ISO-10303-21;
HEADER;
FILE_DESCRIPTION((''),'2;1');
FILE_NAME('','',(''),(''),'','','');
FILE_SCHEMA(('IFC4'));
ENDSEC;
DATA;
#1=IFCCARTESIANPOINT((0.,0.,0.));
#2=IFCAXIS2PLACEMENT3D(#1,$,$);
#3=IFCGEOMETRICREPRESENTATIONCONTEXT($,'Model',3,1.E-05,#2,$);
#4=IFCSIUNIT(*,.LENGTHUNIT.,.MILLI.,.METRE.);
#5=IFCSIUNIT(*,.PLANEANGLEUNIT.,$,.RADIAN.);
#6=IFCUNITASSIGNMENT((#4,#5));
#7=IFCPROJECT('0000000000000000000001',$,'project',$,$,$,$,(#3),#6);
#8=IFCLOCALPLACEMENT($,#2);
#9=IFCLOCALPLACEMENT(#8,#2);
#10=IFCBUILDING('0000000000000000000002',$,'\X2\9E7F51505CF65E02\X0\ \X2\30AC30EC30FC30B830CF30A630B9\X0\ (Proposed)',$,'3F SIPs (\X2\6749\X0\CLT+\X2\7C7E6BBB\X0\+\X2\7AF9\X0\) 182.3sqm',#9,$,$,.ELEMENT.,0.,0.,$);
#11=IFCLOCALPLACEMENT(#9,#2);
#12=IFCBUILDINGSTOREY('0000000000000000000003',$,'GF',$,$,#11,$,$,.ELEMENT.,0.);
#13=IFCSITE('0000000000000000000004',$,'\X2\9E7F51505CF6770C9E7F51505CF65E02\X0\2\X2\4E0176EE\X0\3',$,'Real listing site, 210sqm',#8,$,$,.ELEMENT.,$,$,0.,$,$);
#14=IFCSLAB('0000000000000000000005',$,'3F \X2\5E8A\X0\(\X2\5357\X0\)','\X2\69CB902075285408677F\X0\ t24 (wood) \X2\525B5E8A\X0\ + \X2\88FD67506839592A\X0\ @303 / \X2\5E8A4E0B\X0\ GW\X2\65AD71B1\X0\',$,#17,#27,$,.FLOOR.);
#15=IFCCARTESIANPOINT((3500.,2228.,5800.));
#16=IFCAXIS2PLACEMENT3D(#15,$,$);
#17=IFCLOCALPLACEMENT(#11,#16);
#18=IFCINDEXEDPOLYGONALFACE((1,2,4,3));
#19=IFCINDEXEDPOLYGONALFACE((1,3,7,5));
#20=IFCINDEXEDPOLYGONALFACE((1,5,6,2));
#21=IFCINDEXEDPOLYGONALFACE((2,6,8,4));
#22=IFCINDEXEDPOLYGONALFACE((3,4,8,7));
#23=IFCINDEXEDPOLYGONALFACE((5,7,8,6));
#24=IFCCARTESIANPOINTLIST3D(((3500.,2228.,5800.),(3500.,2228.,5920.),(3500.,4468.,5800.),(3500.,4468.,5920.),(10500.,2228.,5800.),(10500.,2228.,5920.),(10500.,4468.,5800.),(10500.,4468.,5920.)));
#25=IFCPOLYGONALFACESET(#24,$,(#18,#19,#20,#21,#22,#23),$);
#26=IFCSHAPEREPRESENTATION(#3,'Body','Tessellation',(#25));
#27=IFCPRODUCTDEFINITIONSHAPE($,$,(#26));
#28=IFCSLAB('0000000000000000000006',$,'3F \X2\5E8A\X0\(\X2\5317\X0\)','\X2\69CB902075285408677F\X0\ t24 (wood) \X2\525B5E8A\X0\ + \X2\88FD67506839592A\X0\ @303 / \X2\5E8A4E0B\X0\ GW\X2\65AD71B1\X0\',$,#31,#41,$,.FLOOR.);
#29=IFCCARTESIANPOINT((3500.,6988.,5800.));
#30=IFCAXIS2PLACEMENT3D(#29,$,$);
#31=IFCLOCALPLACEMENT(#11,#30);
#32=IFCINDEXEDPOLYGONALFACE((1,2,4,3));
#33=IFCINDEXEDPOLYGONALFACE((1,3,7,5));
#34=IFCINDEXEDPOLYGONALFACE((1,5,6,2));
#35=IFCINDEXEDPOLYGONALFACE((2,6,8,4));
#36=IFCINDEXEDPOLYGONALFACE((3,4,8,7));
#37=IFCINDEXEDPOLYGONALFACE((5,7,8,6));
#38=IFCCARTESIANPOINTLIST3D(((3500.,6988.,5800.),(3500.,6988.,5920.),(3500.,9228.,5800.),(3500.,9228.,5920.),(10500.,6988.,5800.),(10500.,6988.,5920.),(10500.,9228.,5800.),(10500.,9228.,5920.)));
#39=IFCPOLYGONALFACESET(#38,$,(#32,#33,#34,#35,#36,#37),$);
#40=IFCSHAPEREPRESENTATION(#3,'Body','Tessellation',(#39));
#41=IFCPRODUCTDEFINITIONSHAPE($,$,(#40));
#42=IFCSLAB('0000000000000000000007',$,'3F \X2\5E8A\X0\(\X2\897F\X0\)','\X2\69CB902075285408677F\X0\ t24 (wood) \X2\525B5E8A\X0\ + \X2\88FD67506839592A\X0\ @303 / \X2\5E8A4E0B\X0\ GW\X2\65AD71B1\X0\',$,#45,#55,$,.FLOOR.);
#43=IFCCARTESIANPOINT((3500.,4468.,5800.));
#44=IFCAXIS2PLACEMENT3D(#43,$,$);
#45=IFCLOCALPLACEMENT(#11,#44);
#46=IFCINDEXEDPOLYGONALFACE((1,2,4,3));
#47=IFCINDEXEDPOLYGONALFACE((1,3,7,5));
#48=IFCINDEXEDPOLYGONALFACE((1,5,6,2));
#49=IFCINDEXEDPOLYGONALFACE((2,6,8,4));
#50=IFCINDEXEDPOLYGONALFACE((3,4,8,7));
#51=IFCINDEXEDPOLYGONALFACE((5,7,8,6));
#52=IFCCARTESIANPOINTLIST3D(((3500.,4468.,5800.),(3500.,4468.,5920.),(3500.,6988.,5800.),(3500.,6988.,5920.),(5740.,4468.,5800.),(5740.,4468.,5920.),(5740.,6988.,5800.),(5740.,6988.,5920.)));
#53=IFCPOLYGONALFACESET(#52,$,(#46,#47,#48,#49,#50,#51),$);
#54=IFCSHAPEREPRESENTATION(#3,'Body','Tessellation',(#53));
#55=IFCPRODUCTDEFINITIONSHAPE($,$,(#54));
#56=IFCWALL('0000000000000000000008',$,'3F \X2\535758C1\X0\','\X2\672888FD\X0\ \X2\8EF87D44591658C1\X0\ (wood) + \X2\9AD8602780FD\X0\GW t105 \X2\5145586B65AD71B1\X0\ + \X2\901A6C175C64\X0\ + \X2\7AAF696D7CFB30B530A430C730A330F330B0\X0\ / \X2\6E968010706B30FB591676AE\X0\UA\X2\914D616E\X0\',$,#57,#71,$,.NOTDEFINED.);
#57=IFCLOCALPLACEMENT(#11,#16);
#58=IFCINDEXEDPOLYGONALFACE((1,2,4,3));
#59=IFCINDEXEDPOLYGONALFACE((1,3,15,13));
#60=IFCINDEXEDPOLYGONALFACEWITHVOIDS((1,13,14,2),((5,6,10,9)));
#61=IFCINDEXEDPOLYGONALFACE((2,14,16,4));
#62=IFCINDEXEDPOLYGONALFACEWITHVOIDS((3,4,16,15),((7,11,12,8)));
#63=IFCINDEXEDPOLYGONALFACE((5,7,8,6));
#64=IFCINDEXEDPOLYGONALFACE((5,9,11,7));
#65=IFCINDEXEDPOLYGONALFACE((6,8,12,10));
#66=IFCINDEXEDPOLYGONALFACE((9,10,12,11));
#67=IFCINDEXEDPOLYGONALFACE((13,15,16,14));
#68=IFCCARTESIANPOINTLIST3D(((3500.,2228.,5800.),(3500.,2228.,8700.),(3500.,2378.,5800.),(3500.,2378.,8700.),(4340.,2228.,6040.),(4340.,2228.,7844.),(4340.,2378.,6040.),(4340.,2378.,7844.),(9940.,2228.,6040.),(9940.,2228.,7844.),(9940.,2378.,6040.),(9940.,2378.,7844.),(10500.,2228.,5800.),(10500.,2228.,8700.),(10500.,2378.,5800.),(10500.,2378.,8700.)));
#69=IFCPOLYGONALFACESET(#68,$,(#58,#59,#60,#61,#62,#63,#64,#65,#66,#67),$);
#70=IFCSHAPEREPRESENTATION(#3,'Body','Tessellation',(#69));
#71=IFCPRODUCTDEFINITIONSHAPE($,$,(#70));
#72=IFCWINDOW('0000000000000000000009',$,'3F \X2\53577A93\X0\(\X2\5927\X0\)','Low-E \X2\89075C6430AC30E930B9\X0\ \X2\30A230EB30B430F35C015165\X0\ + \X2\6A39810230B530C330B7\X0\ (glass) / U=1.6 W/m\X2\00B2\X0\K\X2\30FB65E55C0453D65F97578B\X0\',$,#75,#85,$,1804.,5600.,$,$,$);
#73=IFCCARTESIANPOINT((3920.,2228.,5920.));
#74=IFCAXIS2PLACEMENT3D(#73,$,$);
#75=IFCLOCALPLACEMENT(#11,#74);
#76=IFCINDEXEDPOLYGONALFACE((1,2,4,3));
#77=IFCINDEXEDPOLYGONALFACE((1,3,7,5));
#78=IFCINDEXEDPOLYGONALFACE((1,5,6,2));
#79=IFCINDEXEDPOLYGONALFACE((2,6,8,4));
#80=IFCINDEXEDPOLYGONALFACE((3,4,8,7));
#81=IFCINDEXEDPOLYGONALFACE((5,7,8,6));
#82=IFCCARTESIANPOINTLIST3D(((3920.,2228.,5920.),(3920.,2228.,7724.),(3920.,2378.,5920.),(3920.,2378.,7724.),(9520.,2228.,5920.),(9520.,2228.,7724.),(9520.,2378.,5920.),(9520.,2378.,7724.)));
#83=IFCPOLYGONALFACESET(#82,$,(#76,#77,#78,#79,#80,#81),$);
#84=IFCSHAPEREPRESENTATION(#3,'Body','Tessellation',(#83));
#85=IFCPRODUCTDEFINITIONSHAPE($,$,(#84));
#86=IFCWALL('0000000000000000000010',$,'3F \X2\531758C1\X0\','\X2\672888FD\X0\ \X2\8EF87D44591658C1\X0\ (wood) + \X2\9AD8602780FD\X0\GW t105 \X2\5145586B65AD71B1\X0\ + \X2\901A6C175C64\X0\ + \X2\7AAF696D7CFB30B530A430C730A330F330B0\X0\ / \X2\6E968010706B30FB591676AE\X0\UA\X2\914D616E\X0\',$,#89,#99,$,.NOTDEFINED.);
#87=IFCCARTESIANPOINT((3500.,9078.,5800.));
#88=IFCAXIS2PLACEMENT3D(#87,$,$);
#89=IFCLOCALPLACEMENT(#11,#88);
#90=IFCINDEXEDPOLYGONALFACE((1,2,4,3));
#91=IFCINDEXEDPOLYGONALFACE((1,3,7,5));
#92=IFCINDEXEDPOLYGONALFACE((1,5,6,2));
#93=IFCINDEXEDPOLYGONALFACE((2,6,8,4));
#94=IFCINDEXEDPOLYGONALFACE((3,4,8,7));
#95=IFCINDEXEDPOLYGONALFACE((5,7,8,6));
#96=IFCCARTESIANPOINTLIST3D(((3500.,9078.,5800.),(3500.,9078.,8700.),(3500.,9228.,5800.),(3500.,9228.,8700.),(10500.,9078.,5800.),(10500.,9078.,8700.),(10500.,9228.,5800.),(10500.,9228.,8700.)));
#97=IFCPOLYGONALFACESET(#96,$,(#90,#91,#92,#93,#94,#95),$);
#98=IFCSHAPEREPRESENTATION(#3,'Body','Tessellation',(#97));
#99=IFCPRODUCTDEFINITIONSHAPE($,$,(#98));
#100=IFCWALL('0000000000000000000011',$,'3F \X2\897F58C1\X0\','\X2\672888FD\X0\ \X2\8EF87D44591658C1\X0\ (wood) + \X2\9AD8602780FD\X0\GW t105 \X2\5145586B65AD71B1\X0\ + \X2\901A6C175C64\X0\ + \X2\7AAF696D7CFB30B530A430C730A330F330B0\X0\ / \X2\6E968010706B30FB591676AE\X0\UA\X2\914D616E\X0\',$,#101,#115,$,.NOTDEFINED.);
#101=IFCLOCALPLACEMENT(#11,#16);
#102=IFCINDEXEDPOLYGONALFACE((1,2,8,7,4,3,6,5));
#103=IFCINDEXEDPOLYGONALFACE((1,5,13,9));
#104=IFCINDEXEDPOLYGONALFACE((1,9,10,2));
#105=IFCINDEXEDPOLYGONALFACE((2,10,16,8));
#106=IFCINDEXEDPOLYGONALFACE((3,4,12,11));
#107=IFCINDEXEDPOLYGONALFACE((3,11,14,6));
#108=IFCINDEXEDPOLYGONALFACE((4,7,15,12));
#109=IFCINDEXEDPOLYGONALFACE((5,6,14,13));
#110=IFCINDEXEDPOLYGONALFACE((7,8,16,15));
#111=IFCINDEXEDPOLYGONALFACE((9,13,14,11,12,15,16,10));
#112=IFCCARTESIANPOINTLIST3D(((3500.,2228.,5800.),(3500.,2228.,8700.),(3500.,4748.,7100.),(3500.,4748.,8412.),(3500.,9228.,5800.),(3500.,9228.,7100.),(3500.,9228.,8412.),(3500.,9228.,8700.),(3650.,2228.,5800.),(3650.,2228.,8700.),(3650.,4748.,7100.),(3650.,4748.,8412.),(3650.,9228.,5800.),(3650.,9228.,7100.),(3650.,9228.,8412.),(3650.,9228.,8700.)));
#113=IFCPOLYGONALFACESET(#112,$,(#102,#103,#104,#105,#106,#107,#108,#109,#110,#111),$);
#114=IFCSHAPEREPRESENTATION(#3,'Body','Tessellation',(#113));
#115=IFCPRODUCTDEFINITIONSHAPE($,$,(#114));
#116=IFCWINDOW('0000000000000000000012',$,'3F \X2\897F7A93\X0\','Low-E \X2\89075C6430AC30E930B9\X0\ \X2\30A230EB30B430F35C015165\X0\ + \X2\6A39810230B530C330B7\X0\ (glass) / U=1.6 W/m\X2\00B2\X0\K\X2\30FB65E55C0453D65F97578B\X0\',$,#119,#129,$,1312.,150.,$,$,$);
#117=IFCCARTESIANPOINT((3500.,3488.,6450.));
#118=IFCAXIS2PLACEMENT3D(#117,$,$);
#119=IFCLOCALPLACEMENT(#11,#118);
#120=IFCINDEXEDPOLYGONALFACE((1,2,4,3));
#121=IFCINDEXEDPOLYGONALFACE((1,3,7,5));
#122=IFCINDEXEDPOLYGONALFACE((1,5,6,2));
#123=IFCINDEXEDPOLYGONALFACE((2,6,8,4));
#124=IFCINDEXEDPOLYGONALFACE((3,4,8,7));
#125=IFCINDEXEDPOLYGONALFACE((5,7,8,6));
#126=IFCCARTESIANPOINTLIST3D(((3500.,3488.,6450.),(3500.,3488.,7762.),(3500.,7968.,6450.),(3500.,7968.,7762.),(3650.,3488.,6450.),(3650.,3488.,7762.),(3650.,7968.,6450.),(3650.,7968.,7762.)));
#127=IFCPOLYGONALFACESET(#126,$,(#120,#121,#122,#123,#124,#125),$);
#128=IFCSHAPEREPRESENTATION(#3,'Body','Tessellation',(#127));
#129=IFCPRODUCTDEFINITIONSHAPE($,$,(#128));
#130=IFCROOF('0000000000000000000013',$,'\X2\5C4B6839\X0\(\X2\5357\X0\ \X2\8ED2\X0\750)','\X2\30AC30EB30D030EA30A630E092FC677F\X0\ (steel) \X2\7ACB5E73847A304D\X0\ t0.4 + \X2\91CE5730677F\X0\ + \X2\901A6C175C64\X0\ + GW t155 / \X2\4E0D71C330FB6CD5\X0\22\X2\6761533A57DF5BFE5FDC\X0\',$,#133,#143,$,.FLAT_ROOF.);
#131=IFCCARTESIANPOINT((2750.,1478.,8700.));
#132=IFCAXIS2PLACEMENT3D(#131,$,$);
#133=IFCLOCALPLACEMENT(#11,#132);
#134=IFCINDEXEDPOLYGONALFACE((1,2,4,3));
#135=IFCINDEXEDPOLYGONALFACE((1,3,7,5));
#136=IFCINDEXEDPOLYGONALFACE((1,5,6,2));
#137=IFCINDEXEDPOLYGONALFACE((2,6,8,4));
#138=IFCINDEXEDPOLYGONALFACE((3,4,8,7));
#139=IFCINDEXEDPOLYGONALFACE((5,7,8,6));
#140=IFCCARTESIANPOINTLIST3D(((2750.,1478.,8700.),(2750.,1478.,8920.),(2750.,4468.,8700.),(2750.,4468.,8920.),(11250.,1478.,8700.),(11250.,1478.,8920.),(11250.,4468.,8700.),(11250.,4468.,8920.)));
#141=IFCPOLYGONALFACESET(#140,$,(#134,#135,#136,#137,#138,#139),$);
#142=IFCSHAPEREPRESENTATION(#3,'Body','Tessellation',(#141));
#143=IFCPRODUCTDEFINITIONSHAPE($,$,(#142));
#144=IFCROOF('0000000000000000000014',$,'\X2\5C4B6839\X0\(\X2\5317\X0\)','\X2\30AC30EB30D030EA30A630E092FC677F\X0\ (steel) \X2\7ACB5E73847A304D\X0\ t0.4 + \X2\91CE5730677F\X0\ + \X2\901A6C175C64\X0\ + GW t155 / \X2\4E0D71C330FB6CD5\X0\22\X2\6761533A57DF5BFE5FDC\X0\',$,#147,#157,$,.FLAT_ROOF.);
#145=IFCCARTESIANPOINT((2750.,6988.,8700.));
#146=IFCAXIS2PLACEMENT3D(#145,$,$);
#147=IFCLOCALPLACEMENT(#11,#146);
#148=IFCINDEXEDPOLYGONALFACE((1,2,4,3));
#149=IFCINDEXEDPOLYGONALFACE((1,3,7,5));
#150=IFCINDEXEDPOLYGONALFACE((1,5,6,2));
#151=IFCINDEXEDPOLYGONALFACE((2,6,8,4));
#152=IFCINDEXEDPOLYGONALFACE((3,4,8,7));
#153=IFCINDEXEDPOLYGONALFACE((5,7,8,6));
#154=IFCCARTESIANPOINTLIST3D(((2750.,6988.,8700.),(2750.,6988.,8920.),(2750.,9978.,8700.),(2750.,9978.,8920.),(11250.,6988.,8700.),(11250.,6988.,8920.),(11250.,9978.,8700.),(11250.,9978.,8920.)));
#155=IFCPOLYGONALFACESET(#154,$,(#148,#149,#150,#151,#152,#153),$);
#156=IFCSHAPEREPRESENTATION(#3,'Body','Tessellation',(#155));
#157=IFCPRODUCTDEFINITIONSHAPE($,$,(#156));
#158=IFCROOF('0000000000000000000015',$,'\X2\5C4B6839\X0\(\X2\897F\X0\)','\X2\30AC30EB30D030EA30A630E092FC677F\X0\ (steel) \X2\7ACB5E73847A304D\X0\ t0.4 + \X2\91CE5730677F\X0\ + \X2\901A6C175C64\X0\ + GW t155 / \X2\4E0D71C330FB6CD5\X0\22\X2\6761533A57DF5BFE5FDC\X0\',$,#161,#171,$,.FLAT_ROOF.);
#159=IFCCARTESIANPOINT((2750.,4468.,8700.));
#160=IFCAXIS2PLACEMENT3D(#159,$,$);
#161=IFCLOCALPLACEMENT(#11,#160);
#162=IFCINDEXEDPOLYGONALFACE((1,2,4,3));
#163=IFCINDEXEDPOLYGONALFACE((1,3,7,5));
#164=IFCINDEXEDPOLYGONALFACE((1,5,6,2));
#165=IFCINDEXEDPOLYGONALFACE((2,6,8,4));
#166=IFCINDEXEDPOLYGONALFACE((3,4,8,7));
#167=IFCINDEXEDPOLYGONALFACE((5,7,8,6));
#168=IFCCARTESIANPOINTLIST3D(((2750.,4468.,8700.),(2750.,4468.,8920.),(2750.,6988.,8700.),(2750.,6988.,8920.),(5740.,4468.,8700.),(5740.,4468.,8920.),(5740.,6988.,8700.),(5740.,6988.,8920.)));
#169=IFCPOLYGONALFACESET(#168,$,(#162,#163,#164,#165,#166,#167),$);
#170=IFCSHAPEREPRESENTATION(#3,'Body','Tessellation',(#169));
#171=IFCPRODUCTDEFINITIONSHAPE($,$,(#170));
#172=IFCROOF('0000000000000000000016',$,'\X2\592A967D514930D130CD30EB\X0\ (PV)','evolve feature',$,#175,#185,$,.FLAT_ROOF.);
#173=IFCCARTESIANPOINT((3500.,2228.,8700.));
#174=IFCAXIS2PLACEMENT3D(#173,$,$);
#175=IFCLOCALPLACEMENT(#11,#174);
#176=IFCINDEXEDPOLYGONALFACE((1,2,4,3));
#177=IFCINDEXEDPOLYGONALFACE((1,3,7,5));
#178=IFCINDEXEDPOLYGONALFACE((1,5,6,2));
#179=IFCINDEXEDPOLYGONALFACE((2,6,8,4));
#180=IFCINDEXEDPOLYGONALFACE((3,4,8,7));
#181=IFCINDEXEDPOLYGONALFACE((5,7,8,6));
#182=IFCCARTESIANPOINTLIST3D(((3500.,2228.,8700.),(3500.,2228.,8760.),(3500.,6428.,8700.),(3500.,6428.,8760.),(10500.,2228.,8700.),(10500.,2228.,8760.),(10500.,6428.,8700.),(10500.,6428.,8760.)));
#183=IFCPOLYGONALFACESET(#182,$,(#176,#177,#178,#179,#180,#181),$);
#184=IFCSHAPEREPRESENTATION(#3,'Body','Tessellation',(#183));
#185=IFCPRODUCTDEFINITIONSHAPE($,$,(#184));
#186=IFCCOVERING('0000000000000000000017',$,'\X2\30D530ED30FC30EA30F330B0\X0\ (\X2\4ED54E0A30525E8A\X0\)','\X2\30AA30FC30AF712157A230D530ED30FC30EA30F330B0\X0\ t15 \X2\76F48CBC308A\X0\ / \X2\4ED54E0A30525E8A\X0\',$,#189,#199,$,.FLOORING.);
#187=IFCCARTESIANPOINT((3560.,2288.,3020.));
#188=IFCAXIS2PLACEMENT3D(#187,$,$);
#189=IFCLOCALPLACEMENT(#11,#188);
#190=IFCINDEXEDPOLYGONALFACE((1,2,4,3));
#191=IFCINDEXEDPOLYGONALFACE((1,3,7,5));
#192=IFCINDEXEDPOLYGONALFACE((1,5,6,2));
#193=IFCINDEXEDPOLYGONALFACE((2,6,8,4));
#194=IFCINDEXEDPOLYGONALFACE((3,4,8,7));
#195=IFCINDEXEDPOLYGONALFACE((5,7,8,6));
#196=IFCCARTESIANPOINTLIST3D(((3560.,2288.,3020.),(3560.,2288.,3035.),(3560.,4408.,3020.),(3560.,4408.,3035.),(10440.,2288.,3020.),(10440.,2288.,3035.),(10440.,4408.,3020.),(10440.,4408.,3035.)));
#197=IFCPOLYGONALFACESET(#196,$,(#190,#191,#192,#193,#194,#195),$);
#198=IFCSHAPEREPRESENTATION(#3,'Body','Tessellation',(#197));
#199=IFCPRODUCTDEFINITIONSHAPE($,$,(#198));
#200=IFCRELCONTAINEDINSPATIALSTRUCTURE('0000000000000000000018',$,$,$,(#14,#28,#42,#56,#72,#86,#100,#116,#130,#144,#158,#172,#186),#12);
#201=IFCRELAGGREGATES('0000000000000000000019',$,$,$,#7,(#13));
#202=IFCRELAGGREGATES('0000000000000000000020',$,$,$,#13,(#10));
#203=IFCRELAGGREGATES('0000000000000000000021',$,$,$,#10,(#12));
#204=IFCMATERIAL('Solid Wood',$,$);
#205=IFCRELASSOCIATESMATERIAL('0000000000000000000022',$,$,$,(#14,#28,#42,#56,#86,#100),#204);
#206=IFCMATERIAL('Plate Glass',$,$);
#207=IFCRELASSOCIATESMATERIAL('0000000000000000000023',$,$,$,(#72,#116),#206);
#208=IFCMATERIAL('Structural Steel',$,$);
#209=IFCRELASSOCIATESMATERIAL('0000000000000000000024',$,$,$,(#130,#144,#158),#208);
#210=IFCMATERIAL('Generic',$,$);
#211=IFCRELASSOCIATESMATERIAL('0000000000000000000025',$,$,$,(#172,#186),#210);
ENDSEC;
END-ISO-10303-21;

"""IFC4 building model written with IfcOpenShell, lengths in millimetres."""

from ifc_helpers import new_model, si_unit, frame, frame_2d, origin, place, context, project, spatial, rectangle, extrude, material, element, fill, save


model = new_model("IFC4")

# Units and contexts
model_context = context("Model", 3, precision=1e-05, world=origin())
ifc_project = project(units=[si_unit("LENGTHUNIT", "METRE", prefix="MILLI"), si_unit("PLANEANGLEUNIT", "RADIAN")], contexts=[model_context])

# Site, building, storey
site_placement = place(None, origin())
site = spatial("IfcSite", under=ifc_project, at=site_placement, Name="鹿児島県鹿児島市2丁目3", ObjectType="Real listing site, 210sqm", CompositionType="ELEMENT", RefElevation=0.0)
building_placement = place(site_placement, origin())
building = spatial("IfcBuilding", under=site, at=building_placement, Name="鹿児島市 ガレージハウス (Proposed)", ObjectType="3F SIPs (杉CLT+籾殻+竹) 182.3sqm", CompositionType="ELEMENT", ElevationOfRefHeight=0.0, ElevationOfTerrain=0.0)
storey_placement = place(building_placement, origin())
storey = spatial("IfcBuildingStorey", under=building, at=storey_placement, Name="GF", CompositionType="ELEMENT", Elevation=0.0)

# Slabs
ifc_material_1 = material(Name="Solid Wood")
slab_1_placement = place(storey_placement, frame((3500.0, 2228.0, 5800.0)))
element("IfcSlab", 1, at=slab_1_placement, inside=storey, material=ifc_material_1, Name="3F 床(南)", Description="構造用合板 t24 (wood) 剛床 + 製材根太 @303 / 床下 GW断熱", PredefinedType="FLOOR", context=model_context, shape_type="SweptSolid", body=[
    extrude(rectangle(XDim=7000.0, YDim=2240.0, at=frame_2d((3500.0, 1120.0))), frame((3500.0, 2228.0, 5800.0)), (0.0, 0.0, 1.0), 120.0),
])
slab_2_placement = place(storey_placement, frame((3500.0, 6988.0, 5800.0)))
element("IfcSlab", 2, at=slab_2_placement, inside=storey, material=ifc_material_1, Name="3F 床(北)", Description="構造用合板 t24 (wood) 剛床 + 製材根太 @303 / 床下 GW断熱", PredefinedType="FLOOR", context=model_context, shape_type="SweptSolid", body=[
    extrude(rectangle(XDim=7000.0, YDim=2240.0, at=frame_2d((3500.0, 1120.0))), frame((3500.0, 6988.0, 5800.0)), (0.0, 0.0, 1.0), 120.0),
])
slab_3_placement = place(storey_placement, frame((3500.0, 4468.0, 5800.0)))
element("IfcSlab", 3, at=slab_3_placement, inside=storey, material=ifc_material_1, Name="3F 床(西)", Description="構造用合板 t24 (wood) 剛床 + 製材根太 @303 / 床下 GW断熱", PredefinedType="FLOOR", context=model_context, shape_type="SweptSolid", body=[
    extrude(rectangle(XDim=2240.0, YDim=2520.0, at=frame_2d((1120.0, 1260.0))), frame((3500.0, 4468.0, 5800.0)), (0.0, 0.0, 1.0), 120.0),
])

# Wall, opening, window
wall_1_placement = place(storey_placement, frame((3500.0, 2228.0, 5800.0)))
wall_1 = element("IfcWall", 4, at=wall_1_placement, inside=storey, material=ifc_material_1, Name="3F 南壁", Description="木製 軸組外壁 (wood) + 高性能GW t105 充填断熱 + 通気層 + 窯業系サイディング / 準耐火・外皮UA配慮", PredefinedType="NOTDEFINED", context=model_context, shape_type="SweptSolid", body=[
    extrude(rectangle(XDim=7000.0, YDim=150.0, at=frame_2d((3500.0, 75.0))), frame((3500.0, 2228.0, 5800.0)), (0.0, 0.0, 1.0), 2900.0),
])
opening_1_placement = place(storey_placement, frame((3920.0, 2228.0, 5920.0)))
opening_1 = element("IfcOpeningElement", 5, at=opening_1_placement, cuts=wall_1, PredefinedType="NOTDEFINED", context=model_context, shape_type="SweptSolid", body=[
    extrude(rectangle(XDim=5600.0, YDim=150.0, at=frame_2d((2800.0, 75.0))), frame((3920.0, 2228.0, 5920.0)), (0.0, 0.0, 1.0), 1804.0),
])
ifc_material_2 = material(Name="Plate Glass")
window_1_placement = place(storey_placement, frame((3920.0, 2228.0, 5920.0)))
window_1 = element("IfcWindow", 6, at=window_1_placement, inside=storey, material=ifc_material_2, Name="3F 南窓(大)", Description="Low-E 複層ガラス アルゴン封入 + 樹脂サッシ (glass) / U=1.6 W/m²K・日射取得型", OverallHeight=1804.0, OverallWidth=5600.0, context=model_context, shape_type="SweptSolid", body=[
    extrude(rectangle(XDim=5600.0, YDim=150.0, at=frame_2d((2800.0, 75.0))), frame((3920.0, 2228.0, 5920.0)), (0.0, 0.0, 1.0), 1804.0),
])
fill(opening_1, window_1)

# Wall
wall_2_placement = place(storey_placement, frame((3500.0, 9078.0, 5800.0)))
element("IfcWall", 7, at=wall_2_placement, inside=storey, material=ifc_material_1, Name="3F 北壁", Description="木製 軸組外壁 (wood) + 高性能GW t105 充填断熱 + 通気層 + 窯業系サイディング / 準耐火・外皮UA配慮", PredefinedType="NOTDEFINED", context=model_context, shape_type="SweptSolid", body=[
    extrude(rectangle(XDim=7000.0, YDim=150.0, at=frame_2d((3500.0, 75.0))), frame((3500.0, 9078.0, 5800.0)), (0.0, 0.0, 1.0), 2900.0),
])

# Wall, opening, window
wall_3_placement = place(storey_placement, frame((3500.0, 2228.0, 5800.0)))
wall_3 = element("IfcWall", 8, at=wall_3_placement, inside=storey, material=ifc_material_1, Name="3F 西壁", Description="木製 軸組外壁 (wood) + 高性能GW t105 充填断熱 + 通気層 + 窯業系サイディング / 準耐火・外皮UA配慮", PredefinedType="NOTDEFINED", context=model_context, shape_type="SweptSolid", body=[
    extrude(rectangle(XDim=150.0, YDim=7000.0, at=frame_2d((75.0, 3500.0))), frame((3500.0, 2228.0, 5800.0)), (0.0, 0.0, 1.0), 2900.0),
])
opening_2_placement = place(storey_placement, frame((3500.0, 3488.0, 6450.0)))
opening_2 = element("IfcOpeningElement", 9, at=opening_2_placement, cuts=wall_3, PredefinedType="NOTDEFINED", context=model_context, shape_type="SweptSolid", body=[
    extrude(rectangle(XDim=150.0, YDim=4480.0, at=frame_2d((75.0, 2240.0))), frame((3500.0, 3488.0, 6450.0)), (0.0, 0.0, 1.0), 1312.0),
])
window_2_placement = place(storey_placement, frame((3500.0, 3488.0, 6450.0)))
window_2 = element("IfcWindow", 10, at=window_2_placement, inside=storey, material=ifc_material_2, Name="3F 西窓", Description="Low-E 複層ガラス アルゴン封入 + 樹脂サッシ (glass) / U=1.6 W/m²K・日射取得型", OverallHeight=1312.0, OverallWidth=150.0, context=model_context, shape_type="SweptSolid", body=[
    extrude(rectangle(XDim=150.0, YDim=4480.0, at=frame_2d((75.0, 2240.0))), frame((3500.0, 3488.0, 6450.0)), (0.0, 0.0, 1.0), 1312.0),
])
fill(opening_2, window_2)

# Roofs
ifc_material_3 = material(Name="Structural Steel")
roof_1_placement = place(storey_placement, frame((2750.0, 1478.0, 8700.0)))
element("IfcRoof", 11, at=roof_1_placement, inside=storey, material=ifc_material_3, Name="屋根(南 軒750)", Description="ガルバリウム鋼板 (steel) 立平葺き t0.4 + 野地板 + 通気層 + GW t155 / 不燃・法22条区域対応", PredefinedType="FLAT_ROOF", context=model_context, shape_type="SweptSolid", body=[
    extrude(rectangle(XDim=8500.0, YDim=2990.0, at=frame_2d((4250.0, 1495.0))), frame((2750.0, 1478.0, 8700.0)), (0.0, 0.0, 1.0), 220.0),
])
roof_2_placement = place(storey_placement, frame((2750.0, 6988.0, 8700.0)))
element("IfcRoof", 12, at=roof_2_placement, inside=storey, material=ifc_material_3, Name="屋根(北)", Description="ガルバリウム鋼板 (steel) 立平葺き t0.4 + 野地板 + 通気層 + GW t155 / 不燃・法22条区域対応", PredefinedType="FLAT_ROOF", context=model_context, shape_type="SweptSolid", body=[
    extrude(rectangle(XDim=8500.0, YDim=2990.0, at=frame_2d((4250.0, 1495.0))), frame((2750.0, 6988.0, 8700.0)), (0.0, 0.0, 1.0), 220.0),
])
roof_3_placement = place(storey_placement, frame((2750.0, 4468.0, 8700.0)))
element("IfcRoof", 13, at=roof_3_placement, inside=storey, material=ifc_material_3, Name="屋根(西)", Description="ガルバリウム鋼板 (steel) 立平葺き t0.4 + 野地板 + 通気層 + GW t155 / 不燃・法22条区域対応", PredefinedType="FLAT_ROOF", context=model_context, shape_type="SweptSolid", body=[
    extrude(rectangle(XDim=2990.0, YDim=2520.0, at=frame_2d((1495.0, 1260.0))), frame((2750.0, 4468.0, 8700.0)), (0.0, 0.0, 1.0), 220.0),
])
ifc_material_4 = material(Name="Generic")
roof_4_placement = place(storey_placement, frame((3500.0, 2228.0, 8700.0)))
element("IfcRoof", 14, at=roof_4_placement, inside=storey, material=ifc_material_4, Name="太陽光パネル (PV)", Description="evolve feature", PredefinedType="FLAT_ROOF", context=model_context, shape_type="SweptSolid", body=[
    extrude(rectangle(XDim=7000.0, YDim=4200.0, at=frame_2d((3500.0, 2100.0))), frame((3500.0, 2228.0, 8700.0)), (0.0, 0.0, 1.0), 60.0),
])

# Covering
covering_1_placement = place(storey_placement, frame((3560.0, 2288.0, 3020.0)))
element("IfcCovering", 15, at=covering_1_placement, inside=storey, material=ifc_material_4, Name="フローリング (仕上げ床)", Description="オーク無垢フローリング t15 直貼り / 仕上げ床", PredefinedType="FLOORING", context=model_context, shape_type="SweptSolid", body=[
    extrude(rectangle(XDim=6880.0, YDim=2120.0, at=frame_2d((3440.0, 1060.0))), frame((3560.0, 2288.0, 3020.0)), (0.0, 0.0, 1.0), 15.0),
])

save(model, "model.ifc")
